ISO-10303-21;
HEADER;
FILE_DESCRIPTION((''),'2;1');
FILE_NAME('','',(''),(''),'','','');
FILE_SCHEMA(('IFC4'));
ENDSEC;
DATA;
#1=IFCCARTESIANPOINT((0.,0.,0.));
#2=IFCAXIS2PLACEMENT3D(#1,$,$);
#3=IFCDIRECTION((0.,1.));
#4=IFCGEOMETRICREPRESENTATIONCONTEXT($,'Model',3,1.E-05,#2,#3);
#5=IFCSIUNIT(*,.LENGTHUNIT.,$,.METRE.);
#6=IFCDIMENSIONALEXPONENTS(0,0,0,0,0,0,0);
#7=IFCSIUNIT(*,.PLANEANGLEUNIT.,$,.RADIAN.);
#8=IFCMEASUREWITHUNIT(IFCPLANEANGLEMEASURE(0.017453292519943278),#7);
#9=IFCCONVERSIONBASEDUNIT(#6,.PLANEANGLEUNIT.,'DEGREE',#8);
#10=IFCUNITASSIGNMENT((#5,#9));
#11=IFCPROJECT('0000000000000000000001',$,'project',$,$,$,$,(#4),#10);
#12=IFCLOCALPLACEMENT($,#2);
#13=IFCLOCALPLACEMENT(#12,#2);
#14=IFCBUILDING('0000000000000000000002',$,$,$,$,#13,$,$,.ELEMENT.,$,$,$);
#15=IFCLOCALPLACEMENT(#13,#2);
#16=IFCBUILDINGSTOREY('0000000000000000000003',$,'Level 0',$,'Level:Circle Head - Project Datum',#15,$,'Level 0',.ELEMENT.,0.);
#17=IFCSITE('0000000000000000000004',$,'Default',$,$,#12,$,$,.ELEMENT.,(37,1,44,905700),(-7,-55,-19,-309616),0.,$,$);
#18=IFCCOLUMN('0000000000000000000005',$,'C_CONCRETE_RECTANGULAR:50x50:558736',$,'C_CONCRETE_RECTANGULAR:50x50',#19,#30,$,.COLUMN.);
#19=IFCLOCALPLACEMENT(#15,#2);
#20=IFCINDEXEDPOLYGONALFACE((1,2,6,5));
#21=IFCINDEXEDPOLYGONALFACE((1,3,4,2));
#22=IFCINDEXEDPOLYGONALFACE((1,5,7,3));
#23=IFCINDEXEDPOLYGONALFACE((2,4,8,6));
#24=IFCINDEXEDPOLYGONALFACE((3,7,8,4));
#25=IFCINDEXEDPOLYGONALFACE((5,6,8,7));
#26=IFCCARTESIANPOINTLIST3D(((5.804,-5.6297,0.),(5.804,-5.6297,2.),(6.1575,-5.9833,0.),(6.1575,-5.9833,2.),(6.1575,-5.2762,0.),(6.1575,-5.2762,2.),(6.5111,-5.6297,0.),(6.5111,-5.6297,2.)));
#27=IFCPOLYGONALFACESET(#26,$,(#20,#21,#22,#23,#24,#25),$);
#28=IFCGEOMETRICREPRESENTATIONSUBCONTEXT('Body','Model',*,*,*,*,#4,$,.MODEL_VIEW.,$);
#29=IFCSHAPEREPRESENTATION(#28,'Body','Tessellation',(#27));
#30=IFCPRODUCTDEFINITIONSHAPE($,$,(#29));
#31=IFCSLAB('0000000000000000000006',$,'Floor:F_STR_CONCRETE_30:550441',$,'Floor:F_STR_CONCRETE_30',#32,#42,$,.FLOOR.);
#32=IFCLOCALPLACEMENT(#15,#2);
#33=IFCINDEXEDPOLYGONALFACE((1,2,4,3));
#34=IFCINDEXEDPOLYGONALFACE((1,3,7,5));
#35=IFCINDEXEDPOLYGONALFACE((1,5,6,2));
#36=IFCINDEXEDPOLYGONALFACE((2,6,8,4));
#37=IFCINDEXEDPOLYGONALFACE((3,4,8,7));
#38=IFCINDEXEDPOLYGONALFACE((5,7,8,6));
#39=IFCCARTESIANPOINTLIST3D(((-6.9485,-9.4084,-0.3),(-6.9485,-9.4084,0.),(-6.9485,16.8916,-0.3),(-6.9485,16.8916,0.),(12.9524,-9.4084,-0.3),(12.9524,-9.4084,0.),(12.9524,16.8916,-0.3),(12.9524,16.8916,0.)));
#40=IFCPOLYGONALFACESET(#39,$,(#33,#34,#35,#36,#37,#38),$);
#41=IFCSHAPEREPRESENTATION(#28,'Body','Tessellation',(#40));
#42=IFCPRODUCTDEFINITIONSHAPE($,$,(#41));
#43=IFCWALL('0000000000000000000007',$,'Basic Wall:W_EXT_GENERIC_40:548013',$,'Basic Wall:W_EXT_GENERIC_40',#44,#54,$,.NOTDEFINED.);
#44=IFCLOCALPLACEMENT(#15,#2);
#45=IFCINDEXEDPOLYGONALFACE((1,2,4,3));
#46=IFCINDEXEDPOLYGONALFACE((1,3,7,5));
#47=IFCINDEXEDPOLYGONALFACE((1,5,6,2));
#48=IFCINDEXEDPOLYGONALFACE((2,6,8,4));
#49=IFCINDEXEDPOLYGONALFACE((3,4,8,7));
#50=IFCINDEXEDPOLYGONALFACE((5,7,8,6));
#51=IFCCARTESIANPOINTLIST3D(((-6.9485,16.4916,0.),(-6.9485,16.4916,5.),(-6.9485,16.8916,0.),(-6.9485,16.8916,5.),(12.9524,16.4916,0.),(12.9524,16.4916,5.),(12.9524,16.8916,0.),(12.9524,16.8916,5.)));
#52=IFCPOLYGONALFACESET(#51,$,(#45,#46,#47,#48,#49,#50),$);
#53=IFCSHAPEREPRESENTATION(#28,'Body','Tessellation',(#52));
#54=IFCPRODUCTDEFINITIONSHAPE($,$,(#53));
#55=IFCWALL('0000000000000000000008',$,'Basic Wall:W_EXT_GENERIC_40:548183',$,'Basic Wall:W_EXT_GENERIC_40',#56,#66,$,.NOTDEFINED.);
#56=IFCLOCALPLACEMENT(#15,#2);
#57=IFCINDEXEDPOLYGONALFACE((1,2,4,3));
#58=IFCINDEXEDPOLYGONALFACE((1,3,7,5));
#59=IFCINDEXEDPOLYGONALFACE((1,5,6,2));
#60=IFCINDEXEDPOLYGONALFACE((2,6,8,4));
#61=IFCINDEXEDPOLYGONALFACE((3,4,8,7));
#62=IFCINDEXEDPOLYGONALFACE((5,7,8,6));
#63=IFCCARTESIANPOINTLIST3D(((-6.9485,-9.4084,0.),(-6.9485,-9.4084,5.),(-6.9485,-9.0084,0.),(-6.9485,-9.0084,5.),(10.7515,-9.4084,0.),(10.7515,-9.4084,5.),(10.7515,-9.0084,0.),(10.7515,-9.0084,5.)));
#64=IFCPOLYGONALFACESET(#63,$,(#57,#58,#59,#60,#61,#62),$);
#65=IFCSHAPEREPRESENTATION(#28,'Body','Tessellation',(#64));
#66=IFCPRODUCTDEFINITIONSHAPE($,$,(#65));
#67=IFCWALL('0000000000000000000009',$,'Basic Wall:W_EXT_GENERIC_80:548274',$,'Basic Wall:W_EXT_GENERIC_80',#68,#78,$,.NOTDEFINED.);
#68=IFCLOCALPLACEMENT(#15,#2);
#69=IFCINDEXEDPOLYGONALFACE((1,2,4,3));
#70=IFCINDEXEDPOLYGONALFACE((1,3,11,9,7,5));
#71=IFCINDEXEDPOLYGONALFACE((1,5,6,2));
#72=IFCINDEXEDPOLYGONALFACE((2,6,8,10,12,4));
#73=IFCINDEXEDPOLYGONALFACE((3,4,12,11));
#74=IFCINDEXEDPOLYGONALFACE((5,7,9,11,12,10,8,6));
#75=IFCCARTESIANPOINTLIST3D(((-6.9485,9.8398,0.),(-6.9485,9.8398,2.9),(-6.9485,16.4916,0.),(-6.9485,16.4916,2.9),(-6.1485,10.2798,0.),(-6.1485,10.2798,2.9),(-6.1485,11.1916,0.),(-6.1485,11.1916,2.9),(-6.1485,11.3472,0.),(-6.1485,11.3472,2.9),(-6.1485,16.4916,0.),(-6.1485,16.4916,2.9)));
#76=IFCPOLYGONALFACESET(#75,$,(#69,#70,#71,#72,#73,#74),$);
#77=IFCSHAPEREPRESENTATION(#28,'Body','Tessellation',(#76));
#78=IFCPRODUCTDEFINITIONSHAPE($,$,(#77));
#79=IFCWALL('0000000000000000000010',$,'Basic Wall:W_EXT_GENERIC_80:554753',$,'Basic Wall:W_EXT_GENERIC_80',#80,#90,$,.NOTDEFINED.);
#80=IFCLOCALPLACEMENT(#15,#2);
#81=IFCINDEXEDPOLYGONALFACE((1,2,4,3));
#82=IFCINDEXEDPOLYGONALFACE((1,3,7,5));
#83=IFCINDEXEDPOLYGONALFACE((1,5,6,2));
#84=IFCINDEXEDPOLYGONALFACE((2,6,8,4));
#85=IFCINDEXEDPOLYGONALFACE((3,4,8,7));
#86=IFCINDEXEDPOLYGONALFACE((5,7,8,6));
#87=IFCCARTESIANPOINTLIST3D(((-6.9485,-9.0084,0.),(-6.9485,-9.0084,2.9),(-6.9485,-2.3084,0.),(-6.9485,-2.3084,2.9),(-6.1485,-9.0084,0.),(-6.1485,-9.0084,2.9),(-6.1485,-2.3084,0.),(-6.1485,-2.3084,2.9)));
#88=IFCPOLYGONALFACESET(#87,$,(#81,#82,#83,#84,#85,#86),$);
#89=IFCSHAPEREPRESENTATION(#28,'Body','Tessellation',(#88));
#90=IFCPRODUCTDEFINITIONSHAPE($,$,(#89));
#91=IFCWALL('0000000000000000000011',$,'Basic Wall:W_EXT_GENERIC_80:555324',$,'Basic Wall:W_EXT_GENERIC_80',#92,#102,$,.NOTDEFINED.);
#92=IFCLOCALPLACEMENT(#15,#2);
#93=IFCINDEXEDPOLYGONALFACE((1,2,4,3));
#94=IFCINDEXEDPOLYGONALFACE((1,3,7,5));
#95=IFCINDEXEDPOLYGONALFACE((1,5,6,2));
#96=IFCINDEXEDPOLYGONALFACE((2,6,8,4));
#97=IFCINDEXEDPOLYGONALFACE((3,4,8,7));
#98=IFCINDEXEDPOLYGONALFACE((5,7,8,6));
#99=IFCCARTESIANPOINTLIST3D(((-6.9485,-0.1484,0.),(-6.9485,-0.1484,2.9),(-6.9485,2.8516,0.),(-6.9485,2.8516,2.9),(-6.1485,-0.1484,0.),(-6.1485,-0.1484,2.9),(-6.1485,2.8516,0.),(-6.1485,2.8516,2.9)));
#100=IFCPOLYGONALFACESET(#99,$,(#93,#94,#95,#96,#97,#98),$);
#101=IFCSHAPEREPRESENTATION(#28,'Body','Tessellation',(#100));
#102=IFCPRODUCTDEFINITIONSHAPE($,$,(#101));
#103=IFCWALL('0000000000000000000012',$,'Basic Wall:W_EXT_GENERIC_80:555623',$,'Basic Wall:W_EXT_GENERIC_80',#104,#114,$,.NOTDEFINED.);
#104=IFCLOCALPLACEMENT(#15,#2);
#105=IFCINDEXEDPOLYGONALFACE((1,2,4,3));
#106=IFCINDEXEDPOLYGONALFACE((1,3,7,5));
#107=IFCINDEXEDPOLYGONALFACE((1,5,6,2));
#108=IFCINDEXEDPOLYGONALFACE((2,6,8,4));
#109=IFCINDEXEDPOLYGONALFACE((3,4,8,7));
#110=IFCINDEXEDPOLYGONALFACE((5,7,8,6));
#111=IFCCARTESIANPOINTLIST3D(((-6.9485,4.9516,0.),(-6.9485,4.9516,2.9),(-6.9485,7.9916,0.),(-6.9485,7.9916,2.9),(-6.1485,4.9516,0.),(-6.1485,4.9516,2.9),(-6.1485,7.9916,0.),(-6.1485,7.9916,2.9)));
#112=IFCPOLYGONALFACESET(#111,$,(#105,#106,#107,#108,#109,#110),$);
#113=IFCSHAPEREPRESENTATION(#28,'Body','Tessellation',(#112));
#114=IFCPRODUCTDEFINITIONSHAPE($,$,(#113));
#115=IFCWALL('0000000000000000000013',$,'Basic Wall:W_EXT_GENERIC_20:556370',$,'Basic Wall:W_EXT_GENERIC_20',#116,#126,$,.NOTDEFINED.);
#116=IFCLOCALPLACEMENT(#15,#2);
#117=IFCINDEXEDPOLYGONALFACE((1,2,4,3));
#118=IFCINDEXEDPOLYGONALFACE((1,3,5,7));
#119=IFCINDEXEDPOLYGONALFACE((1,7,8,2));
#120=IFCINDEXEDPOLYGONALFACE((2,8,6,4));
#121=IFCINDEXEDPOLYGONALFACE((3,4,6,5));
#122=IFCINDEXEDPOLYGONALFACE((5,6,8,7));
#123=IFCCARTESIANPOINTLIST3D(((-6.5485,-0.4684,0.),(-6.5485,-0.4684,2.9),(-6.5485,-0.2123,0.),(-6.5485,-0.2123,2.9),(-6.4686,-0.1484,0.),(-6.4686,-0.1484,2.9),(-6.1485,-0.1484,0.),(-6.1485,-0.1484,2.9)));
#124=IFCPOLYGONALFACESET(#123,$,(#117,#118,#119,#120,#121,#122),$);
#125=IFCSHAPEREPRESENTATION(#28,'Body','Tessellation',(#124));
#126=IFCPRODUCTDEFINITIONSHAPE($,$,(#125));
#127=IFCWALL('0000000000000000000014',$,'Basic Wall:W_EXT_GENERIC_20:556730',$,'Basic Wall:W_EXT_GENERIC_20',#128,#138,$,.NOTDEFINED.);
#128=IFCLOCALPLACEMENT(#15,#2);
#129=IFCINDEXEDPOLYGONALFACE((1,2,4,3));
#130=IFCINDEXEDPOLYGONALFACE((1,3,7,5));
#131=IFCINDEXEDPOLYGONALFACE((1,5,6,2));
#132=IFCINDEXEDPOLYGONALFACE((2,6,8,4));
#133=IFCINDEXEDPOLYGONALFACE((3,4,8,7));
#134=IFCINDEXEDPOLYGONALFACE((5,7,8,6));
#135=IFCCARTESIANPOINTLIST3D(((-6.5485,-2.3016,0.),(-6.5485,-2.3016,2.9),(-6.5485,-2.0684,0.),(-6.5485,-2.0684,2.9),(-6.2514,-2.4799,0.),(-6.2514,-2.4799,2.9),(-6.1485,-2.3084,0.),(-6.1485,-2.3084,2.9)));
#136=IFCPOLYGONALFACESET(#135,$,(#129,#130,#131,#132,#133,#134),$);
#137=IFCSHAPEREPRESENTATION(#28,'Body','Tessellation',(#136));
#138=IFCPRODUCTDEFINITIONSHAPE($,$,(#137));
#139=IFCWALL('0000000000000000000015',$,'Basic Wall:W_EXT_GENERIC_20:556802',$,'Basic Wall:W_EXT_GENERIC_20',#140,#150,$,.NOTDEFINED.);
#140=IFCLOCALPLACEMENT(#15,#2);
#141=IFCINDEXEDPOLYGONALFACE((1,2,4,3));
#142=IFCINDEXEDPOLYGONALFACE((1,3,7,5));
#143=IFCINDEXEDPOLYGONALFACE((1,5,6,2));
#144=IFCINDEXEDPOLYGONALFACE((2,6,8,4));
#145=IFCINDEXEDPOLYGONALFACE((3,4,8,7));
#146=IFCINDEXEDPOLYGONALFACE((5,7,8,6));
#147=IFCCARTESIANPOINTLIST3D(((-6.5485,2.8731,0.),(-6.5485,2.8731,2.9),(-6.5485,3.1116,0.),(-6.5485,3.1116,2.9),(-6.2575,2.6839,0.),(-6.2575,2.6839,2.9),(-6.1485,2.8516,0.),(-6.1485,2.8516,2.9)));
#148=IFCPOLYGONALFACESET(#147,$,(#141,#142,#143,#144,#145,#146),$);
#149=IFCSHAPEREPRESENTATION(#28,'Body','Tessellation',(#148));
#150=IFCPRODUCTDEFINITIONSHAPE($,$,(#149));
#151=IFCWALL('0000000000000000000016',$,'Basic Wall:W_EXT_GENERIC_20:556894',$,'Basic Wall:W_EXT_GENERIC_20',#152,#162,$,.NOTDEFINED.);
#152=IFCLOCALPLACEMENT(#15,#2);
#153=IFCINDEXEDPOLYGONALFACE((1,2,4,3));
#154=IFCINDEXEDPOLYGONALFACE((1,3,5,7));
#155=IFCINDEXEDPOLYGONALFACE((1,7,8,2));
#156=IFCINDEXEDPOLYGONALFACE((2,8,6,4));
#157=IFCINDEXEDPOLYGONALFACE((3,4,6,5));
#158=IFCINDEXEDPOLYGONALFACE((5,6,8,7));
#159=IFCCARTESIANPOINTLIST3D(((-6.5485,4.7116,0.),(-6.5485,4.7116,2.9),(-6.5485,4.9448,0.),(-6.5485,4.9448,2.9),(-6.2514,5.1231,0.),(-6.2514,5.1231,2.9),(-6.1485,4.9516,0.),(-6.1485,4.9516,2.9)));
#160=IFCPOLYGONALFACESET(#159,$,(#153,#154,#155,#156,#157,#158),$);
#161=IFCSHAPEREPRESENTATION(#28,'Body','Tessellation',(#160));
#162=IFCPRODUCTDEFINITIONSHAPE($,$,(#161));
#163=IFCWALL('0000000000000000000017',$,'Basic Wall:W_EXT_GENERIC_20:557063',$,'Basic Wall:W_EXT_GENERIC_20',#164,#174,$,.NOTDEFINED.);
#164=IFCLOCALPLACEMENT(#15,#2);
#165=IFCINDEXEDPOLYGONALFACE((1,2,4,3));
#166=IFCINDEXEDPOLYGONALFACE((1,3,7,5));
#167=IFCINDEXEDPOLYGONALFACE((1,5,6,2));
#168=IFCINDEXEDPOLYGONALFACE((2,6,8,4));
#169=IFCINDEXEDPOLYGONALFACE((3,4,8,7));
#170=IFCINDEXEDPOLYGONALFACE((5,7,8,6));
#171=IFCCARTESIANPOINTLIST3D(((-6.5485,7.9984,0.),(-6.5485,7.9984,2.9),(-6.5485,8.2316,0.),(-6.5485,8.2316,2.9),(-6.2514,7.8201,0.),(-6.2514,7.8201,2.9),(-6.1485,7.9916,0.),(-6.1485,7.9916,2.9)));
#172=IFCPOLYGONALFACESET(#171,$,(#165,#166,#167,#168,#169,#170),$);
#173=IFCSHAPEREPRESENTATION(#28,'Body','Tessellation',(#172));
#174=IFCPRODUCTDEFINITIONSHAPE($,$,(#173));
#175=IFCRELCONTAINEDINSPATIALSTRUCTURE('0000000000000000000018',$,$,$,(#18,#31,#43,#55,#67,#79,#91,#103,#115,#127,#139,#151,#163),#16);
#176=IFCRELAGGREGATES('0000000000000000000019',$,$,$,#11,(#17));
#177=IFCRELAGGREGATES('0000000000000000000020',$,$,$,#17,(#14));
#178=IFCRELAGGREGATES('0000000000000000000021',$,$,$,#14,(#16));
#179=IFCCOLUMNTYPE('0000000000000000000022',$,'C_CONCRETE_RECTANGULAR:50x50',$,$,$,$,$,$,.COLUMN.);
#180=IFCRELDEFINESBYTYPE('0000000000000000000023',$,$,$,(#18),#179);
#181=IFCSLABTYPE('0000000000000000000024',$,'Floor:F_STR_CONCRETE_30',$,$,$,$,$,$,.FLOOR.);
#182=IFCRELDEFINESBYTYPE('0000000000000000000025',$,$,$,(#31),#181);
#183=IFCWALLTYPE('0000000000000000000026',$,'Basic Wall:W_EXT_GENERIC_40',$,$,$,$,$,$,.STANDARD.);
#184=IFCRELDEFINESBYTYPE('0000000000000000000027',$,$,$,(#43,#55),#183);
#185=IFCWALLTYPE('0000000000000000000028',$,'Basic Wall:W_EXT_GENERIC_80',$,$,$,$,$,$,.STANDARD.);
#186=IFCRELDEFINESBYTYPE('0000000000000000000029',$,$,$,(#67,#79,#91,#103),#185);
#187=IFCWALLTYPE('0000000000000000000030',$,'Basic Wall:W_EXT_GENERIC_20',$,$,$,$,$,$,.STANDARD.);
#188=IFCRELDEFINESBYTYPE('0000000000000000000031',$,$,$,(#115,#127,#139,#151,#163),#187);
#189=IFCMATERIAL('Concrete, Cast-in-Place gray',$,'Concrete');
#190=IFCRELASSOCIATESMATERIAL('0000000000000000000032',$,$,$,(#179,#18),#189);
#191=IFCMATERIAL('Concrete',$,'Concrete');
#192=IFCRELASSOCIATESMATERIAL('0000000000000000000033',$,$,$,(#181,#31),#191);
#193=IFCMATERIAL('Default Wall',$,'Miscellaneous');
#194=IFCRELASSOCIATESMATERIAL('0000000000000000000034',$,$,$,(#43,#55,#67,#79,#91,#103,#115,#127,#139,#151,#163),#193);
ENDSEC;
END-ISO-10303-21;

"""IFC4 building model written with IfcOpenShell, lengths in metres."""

from ifc_helpers import new_model, entity, si_unit, converted_unit, direction, frame, origin, place, context, subcontext, project, spatial, indexed_curve, outline, extrude, source, transform, mapped, material, type_object, type_shapes, element, save


model = new_model("IFC4")

# Units and contexts
model_context = context("Model", 3, precision=1e-05, world=origin(), true_north=direction((0.0, 1.0)))
body_context = subcontext(model_context, "Body", "Model", "MODEL_VIEW")
ifc_project = project(units=[si_unit("LENGTHUNIT", "METRE"), converted_unit("PLANEANGLEUNIT", "DEGREE", entity("IfcPlaneAngleMeasure", 0.017453292519943278), si_unit("PLANEANGLEUNIT", "RADIAN"), dimensions=[0, 0, 0, 0, 0, 0, 0])], contexts=[model_context])

# Site, building, storey
site_placement = place(None, origin())
site = spatial("IfcSite", under=ifc_project, at=site_placement, Name="Default", CompositionType="ELEMENT", RefLatitude=(37, 1, 44, 905700), RefLongitude=(-7, -55, -19, -309616), RefElevation=0.0)
building_placement = place(site_placement, origin())
building = spatial("IfcBuilding", under=site, at=building_placement, CompositionType="ELEMENT")
storey_placement = place(building_placement, origin())
storey = spatial("IfcBuildingStorey", under=building, at=storey_placement, Name="Level 0", ObjectType="Level:Circle Head - Project Datum", LongName="Level 0", CompositionType="ELEMENT", Elevation=0.0)

# Column
ifc_material_1 = material(Name="Concrete, Cast-in-Place gray", Category="Concrete")
column_type = type_object("IfcColumnType", Name="C_CONCRETE_RECTANGULAR:50x50", PredefinedType="COLUMN", material=ifc_material_1)
shared_shape = source(origin(), body_context, "Body", "SweptSolid", [
    extrude(outline(indexed_curve([(-0.25, -0.25), (0.25, -0.25), (0.25, 0.25), (-0.25, 0.25), (-0.25, -0.25)], self_intersect=False)), frame((0.0, 0.0, 0.0), z_axis=(0.0, 0.0, 1.0), x_axis=(-1.0, 0.0, 0.0)), (0.0, 0.0, 1.0), 2.0),
])
type_shapes(column_type, [shared_shape])
column_placement = place(storey_placement, frame((6.1575, -5.6297, 0.0), z_axis=(0.0, 0.0, 1.0), x_axis=(0.707107, 0.707107, 0.0)))
element("IfcColumn", 1, at=column_placement, inside=storey, type_object=column_type, material=ifc_material_1, Name="C_CONCRETE_RECTANGULAR:50x50:558736", ObjectType="C_CONCRETE_RECTANGULAR:50x50", PredefinedType="COLUMN", context=body_context, shape_type="MappedRepresentation", body=[
    mapped(shared_shape, transform((0.0, 0.0, 0.0), scale=1.0)),
])

# Slab
ifc_material_2 = material(Name="Concrete", Category="Concrete")
slab_type = type_object("IfcSlabType", Name="Floor:F_STR_CONCRETE_30", PredefinedType="FLOOR", material=ifc_material_2)
slab_placement = place(storey_placement, origin())
element("IfcSlab", 2, at=slab_placement, inside=storey, type_object=slab_type, material=ifc_material_2, Name="Floor:F_STR_CONCRETE_30:550441", ObjectType="Floor:F_STR_CONCRETE_30", PredefinedType="FLOOR", context=body_context, shape_type="SweptSolid", body=[
    extrude(outline(indexed_curve([(-13.15, -9.9504), (13.15, -9.9504), (13.15, 9.9504), (-13.15, 9.9504), (-13.15, -9.9504)], self_intersect=False)), frame((3.0019, 3.7416, 0.0), z_axis=(0.0, 0.0, -1.0), x_axis=(0.0, 1.0, 0.0)), (0.0, 0.0, 1.0), 0.3),
])

# Walls
ifc_material_3 = material(Name="Default Wall", Category="Miscellaneous")
wall_type_1 = type_object("IfcWallType", Name="Basic Wall:W_EXT_GENERIC_40", PredefinedType="STANDARD")
wall_1_placement = place(storey_placement, frame((-6.9485, 16.6916, 0.0)))
element("IfcWall", 3, at=wall_1_placement, inside=storey, type_object=wall_type_1, material=ifc_material_3, Name="Basic Wall:W_EXT_GENERIC_40:548013", ObjectType="Basic Wall:W_EXT_GENERIC_40", PredefinedType="NOTDEFINED", context=body_context, shape_type="SweptSolid", body=[
    extrude(outline(indexed_curve([(19.9008, 0.2), (0.0, 0.2), (0.0, -0.2), (19.9008, -0.2), (19.9008, 0.2)], self_intersect=False)), origin(), (0.0, 0.0, 1.0), 5.0),
])
wall_2_placement = place(storey_placement, frame((10.7515, -9.2084, 0.0), z_axis=(0.0, 0.0, 1.0), x_axis=(-1.0, 0.0, 0.0)))
element("IfcWall", 4, at=wall_2_placement, inside=storey, type_object=wall_type_1, material=ifc_material_3, Name="Basic Wall:W_EXT_GENERIC_40:548183", ObjectType="Basic Wall:W_EXT_GENERIC_40", PredefinedType="NOTDEFINED", context=body_context, shape_type="SweptSolid", body=[
    extrude(outline(indexed_curve([(17.7, 0.2), (0.0, 0.2), (0.0, -0.2), (17.7, -0.2), (17.7, 0.2)], self_intersect=False)), origin(), (0.0, 0.0, 1.0), 5.0),
])
wall_type_2 = type_object("IfcWallType", Name="Basic Wall:W_EXT_GENERIC_80", PredefinedType="STANDARD")
wall_3_placement = place(storey_placement, frame((-6.5485, 16.4916, 0.0), z_axis=(0.0, 0.0, 1.0), x_axis=(0.0, -1.0, 0.0)))
element("IfcWall", 5, at=wall_3_placement, inside=storey, type_object=wall_type_2, material=ifc_material_3, Name="Basic Wall:W_EXT_GENERIC_80:548274", ObjectType="Basic Wall:W_EXT_GENERIC_80", PredefinedType="NOTDEFINED", context=body_context, shape_type="SweptSolid", body=[
    extrude(outline(indexed_curve([(6.6517, -0.4), (6.2117, 0.4), (5.3, 0.4), (5.1444, 0.4), (0.0, 0.4), (0.0, -0.4), (6.6517, -0.4)], self_intersect=False)), origin(), (0.0, 0.0, 1.0), 2.9),
])
wall_4_placement = place(storey_placement, frame((-6.5485, -2.3084, 0.0), z_axis=(0.0, 0.0, 1.0), x_axis=(0.0, -1.0, 0.0)))
element("IfcWall", 6, at=wall_4_placement, inside=storey, type_object=wall_type_2, material=ifc_material_3, Name="Basic Wall:W_EXT_GENERIC_80:554753", ObjectType="Basic Wall:W_EXT_GENERIC_80", PredefinedType="NOTDEFINED", context=body_context, shape_type="SweptSolid", body=[
    extrude(outline(indexed_curve([(6.7, 0.4), (0.0, 0.4), (0.0, -0.4), (6.7, -0.4), (6.7, 0.4)], self_intersect=False)), origin(), (0.0, 0.0, 1.0), 2.9),
])
wall_5_placement = place(storey_placement, frame((-6.5485, 2.8516, 0.0), z_axis=(0.0, 0.0, 1.0), x_axis=(0.0, -1.0, 0.0)))
element("IfcWall", 7, at=wall_5_placement, inside=storey, type_object=wall_type_2, material=ifc_material_3, Name="Basic Wall:W_EXT_GENERIC_80:555324", ObjectType="Basic Wall:W_EXT_GENERIC_80", PredefinedType="NOTDEFINED", context=body_context, shape_type="SweptSolid", body=[
    extrude(outline(indexed_curve([(3.0, 0.4), (0.0, 0.4), (0.0, -0.4), (3.0, -0.4), (3.0, 0.4)], self_intersect=False)), origin(), (0.0, 0.0, 1.0), 2.9),
])
wall_6_placement = place(storey_placement, frame((-6.5485, 7.9916, 0.0), z_axis=(0.0, 0.0, 1.0), x_axis=(0.0, -1.0, 0.0)))
element("IfcWall", 8, at=wall_6_placement, inside=storey, type_object=wall_type_2, material=ifc_material_3, Name="Basic Wall:W_EXT_GENERIC_80:555623", ObjectType="Basic Wall:W_EXT_GENERIC_80", PredefinedType="NOTDEFINED", context=body_context, shape_type="SweptSolid", body=[
    extrude(outline(indexed_curve([(3.04, 0.4), (0.0, 0.4), (0.0, -0.4), (3.04, -0.4), (3.04, 0.4)], self_intersect=False)), origin(), (0.0, 0.0, 1.0), 2.9),
])
wall_type_3 = type_object("IfcWallType", Name="Basic Wall:W_EXT_GENERIC_20", PredefinedType="STANDARD")
wall_7_placement = place(storey_placement, frame((-6.2109, -0.0703, 0.0), z_axis=(0.0, 0.0, 1.0), x_axis=(-0.780869, -0.624695, 0.0)))
element("IfcWall", 9, at=wall_7_placement, inside=storey, type_object=wall_type_3, material=ifc_material_3, Name="Basic Wall:W_EXT_GENERIC_20:556370", ObjectType="Basic Wall:W_EXT_GENERIC_20", PredefinedType="NOTDEFINED", context=body_context, shape_type="SweptSolid", body=[
    extrude(outline(indexed_curve([(0.0, 0.1), (0.25, -0.1), (0.3522, -0.1), (0.5122, 0.1), (0.0, 0.1)], self_intersect=False)), origin(), (0.0, 0.0, 1.0), 2.9),
])
wall_8_placement = place(storey_placement, frame((-6.1999, -2.3942, 0.0), z_axis=(0.0, 0.0, 1.0), x_axis=(-0.857493, 0.514496, 0.0)))
element("IfcWall", 10, at=wall_8_placement, inside=storey, type_object=wall_type_3, material=ifc_material_3, Name="Basic Wall:W_EXT_GENERIC_20:556730", ObjectType="Basic Wall:W_EXT_GENERIC_20", PredefinedType="NOTDEFINED", context=body_context, shape_type="SweptSolid", body=[
    extrude(outline(indexed_curve([(0.4665, -0.1), (0.3465, 0.1), (0.0, 0.1), (0.0, -0.1), (0.4665, -0.1)], self_intersect=False)), origin(), (0.0, 0.0, 1.0), 2.9),
])
wall_9_placement = place(storey_placement, frame((-6.203, 2.7677, 0.0), z_axis=(0.0, 0.0, 1.0), x_axis=(-0.838444, 0.544988, 0.0)))
element("IfcWall", 11, at=wall_9_placement, inside=storey, type_object=wall_type_3, material=ifc_material_3, Name="Basic Wall:W_EXT_GENERIC_20:556802", ObjectType="Basic Wall:W_EXT_GENERIC_20", PredefinedType="NOTDEFINED", context=body_context, shape_type="SweptSolid", body=[
    extrude(outline(indexed_curve([(0.4771, -0.1), (0.3471, 0.1), (0.0, 0.1), (0.0, -0.1), (0.4771, -0.1)], self_intersect=False)), origin(), (0.0, 0.0, 1.0), 2.9),
])
wall_10_placement = place(storey_placement, frame((-6.1999, 5.0373, 0.0), z_axis=(0.0, 0.0, 1.0), x_axis=(-0.857493, -0.514496, 0.0)))
element("IfcWall", 12, at=wall_10_placement, inside=storey, type_object=wall_type_3, material=ifc_material_3, Name="Basic Wall:W_EXT_GENERIC_20:556894", ObjectType="Basic Wall:W_EXT_GENERIC_20", PredefinedType="NOTDEFINED", context=body_context, shape_type="SweptSolid", body=[
    extrude(outline(indexed_curve([(0.3465, -0.1), (0.4665, 0.1), (0.0, 0.1), (0.0, -0.1), (0.3465, -0.1)], self_intersect=False)), origin(), (0.0, 0.0, 1.0), 2.9),
])
wall_11_placement = place(storey_placement, frame((-6.1999, 7.9058, 0.0), z_axis=(0.0, 0.0, 1.0), x_axis=(-0.857493, 0.514496, 0.0)))
element("IfcWall", 13, at=wall_11_placement, inside=storey, type_object=wall_type_3, material=ifc_material_3, Name="Basic Wall:W_EXT_GENERIC_20:557063", ObjectType="Basic Wall:W_EXT_GENERIC_20", PredefinedType="NOTDEFINED", context=body_context, shape_type="SweptSolid", body=[
    extrude(outline(indexed_curve([(0.4665, -0.1), (0.3465, 0.1), (0.0, 0.1), (0.0, -0.1), (0.4665, -0.1)], self_intersect=False)), origin(), (0.0, 0.0, 1.0), 2.9),
])

save(model, "model.ifc")
